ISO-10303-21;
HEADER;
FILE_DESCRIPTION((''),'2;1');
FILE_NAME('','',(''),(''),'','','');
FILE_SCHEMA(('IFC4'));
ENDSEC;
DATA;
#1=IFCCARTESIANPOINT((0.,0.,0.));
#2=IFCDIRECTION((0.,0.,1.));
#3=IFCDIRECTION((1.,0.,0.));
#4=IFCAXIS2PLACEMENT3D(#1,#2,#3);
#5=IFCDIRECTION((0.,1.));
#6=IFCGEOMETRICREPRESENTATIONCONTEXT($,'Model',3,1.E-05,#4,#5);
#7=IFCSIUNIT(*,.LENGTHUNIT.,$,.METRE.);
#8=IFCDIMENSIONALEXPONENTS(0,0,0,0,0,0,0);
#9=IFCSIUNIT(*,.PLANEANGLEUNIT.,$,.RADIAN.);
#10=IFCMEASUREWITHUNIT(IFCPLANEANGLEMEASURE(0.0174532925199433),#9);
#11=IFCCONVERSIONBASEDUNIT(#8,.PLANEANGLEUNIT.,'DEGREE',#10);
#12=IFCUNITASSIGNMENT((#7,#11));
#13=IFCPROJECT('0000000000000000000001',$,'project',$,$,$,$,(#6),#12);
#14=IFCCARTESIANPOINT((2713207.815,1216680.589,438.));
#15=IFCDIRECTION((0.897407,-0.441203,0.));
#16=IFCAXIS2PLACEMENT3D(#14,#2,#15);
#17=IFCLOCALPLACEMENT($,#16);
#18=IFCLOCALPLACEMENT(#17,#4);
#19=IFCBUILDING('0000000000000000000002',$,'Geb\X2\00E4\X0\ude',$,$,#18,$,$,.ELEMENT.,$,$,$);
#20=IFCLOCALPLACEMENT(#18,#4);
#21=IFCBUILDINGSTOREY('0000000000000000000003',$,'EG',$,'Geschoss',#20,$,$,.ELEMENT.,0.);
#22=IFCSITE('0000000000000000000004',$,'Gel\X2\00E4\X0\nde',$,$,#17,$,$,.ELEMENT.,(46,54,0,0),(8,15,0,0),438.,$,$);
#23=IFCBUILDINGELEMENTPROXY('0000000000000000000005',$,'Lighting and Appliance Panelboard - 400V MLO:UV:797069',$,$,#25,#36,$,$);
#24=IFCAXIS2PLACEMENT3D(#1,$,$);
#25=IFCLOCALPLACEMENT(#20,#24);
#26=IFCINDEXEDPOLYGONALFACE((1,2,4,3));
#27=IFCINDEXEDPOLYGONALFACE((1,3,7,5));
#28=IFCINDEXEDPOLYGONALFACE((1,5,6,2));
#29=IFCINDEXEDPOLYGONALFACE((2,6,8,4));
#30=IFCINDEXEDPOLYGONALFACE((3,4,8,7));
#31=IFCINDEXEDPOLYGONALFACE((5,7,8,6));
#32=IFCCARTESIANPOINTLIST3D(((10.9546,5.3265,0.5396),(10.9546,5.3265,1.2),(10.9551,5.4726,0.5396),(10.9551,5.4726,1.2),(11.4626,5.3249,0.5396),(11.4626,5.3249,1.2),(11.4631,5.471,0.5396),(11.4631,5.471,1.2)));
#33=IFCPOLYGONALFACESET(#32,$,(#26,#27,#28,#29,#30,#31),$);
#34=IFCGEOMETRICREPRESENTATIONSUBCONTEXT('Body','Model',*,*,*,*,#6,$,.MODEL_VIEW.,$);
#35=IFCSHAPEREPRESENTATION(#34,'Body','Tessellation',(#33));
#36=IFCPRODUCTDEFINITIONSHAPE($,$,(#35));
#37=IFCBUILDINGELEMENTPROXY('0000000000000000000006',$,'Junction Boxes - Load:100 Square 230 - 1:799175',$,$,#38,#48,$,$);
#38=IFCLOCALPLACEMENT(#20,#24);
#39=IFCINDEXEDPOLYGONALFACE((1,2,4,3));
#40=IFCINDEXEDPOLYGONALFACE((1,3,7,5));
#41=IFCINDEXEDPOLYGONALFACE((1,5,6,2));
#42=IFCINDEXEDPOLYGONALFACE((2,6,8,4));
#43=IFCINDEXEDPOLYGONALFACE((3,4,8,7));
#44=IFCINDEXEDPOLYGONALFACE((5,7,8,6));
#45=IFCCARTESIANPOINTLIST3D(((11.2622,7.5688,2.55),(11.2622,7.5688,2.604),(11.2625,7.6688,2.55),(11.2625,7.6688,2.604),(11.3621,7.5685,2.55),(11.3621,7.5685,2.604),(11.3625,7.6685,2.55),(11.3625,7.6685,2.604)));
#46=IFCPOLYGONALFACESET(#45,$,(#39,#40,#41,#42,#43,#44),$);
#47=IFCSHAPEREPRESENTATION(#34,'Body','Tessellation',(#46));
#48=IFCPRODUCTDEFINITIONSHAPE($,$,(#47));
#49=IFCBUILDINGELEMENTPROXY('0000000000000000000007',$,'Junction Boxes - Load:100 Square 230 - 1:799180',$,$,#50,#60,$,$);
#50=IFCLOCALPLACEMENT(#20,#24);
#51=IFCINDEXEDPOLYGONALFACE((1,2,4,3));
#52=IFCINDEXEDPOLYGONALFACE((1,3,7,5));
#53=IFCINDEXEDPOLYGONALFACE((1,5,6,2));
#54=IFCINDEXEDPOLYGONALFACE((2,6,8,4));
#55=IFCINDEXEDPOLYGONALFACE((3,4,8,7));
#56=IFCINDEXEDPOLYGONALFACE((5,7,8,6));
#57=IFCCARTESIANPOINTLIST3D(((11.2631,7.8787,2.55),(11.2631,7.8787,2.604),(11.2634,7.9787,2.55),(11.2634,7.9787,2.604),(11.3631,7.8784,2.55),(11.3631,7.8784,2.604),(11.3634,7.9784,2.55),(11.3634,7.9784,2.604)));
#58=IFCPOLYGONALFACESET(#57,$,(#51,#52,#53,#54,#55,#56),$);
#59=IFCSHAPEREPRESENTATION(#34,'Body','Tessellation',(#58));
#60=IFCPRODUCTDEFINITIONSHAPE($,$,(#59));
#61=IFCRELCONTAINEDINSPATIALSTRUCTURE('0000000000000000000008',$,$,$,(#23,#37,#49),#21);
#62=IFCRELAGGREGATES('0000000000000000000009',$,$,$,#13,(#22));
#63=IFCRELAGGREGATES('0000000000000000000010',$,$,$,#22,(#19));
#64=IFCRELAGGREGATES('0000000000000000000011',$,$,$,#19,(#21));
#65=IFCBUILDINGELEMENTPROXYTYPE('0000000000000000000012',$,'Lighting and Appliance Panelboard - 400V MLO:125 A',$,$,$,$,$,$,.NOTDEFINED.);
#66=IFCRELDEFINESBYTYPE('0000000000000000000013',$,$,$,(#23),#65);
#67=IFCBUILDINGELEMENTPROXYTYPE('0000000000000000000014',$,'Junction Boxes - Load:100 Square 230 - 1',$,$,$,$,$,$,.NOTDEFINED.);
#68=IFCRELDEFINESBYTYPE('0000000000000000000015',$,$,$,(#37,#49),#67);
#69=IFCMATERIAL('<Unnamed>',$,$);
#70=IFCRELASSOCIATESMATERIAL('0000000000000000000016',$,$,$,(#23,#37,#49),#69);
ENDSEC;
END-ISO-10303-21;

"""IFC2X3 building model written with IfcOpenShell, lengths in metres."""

from ifc_helpers import new_model, entity, si_unit, converted_unit, direction, frame, origin_with_axes, origin_2d_with_axis, place, context, subcontext, project, spatial, rectangle, extrude, material, type_object, element, save


model = new_model("IFC2X3")

# Units and contexts
model_context = context("Model", 3, precision=1e-05, world=origin_with_axes(), true_north=direction((0.0, 1.0)))
body_context = subcontext(model_context, "Body", "Model", "MODEL_VIEW")
ifc_project = project(units=[si_unit("LENGTHUNIT", "METRE"), converted_unit("PLANEANGLEUNIT", "DEGREE", entity("IfcPlaneAngleMeasure", 0.0174532925199433), si_unit("PLANEANGLEUNIT", "RADIAN"), dimensions=[0, 0, 0, 0, 0, 0, 0])], contexts=[model_context])

# Site, building, storey
site_placement = place(None, frame((2713207.815, 1216680.589, 438.0), z_axis=(0.0, 0.0, 1.0), x_axis=(0.897407, -0.441203, 0.0)))
site = spatial("IfcSite", under=ifc_project, at=site_placement, Name="Gelände", CompositionType="ELEMENT", RefLatitude=(46, 54, 0, 0), RefLongitude=(8, 15, 0, 0), RefElevation=438.0)
building_placement = place(site_placement, origin_with_axes())
building = spatial("IfcBuilding", under=site, at=building_placement, Name="Gebäude", CompositionType="ELEMENT")
storey_placement = place(building_placement, origin_with_axes())
storey = spatial("IfcBuildingStorey", under=building, at=storey_placement, Name="EG", ObjectType="Geschoss", CompositionType="ELEMENT", Elevation=0.0)

# Building element proxies
ifc_material = material(Name="<Unnamed>")
building_element_proxy_type_1 = type_object("IfcBuildingElementProxyType", Name="Lighting and Appliance Panelboard - 400V MLO:125 A", PredefinedType="NOTDEFINED")
proxy_placement = place(storey_placement, frame((11.2091, 5.4718, 1.2), z_axis=(0.0, 0.0, 1.0), x_axis=(-0.999995, 0.003142, 0.0)))
element("IfcBuildingElementProxy", 1, at=proxy_placement, inside=storey, type_object=building_element_proxy_type_1, material=ifc_material, Name="Lighting and Appliance Panelboard - 400V MLO:UV:797069", context=body_context, shape_type="SweptSolid", body=[
    extrude(rectangle(XDim=0.6604, YDim=0.508, at=origin_2d_with_axis()), frame((0.0, 0.1461, -0.3302), z_axis=(0.0, -1.0, 0.0), x_axis=(0.0, 0.0, 1.0)), (0.0, 0.0, 1.0), 0.1461),
])
building_element_proxy_type_2 = type_object("IfcBuildingElementProxyType", Name="Junction Boxes - Load:100 Square 230 - 1", PredefinedType="NOTDEFINED")
for number, where, z_axis, x_axis, name in (
    (2, (11.3123, 7.6186, 2.55), (0.0, 0.0, 1.0), (-0.00313, -0.999995, 0.0), "Junction Boxes - Load:100 Square 230 - 1:799175"),
    (3, (11.3133, 7.9285, 2.55), (0.0, 0.0, 1.0), (-0.00313, -0.999995, 0.0), "Junction Boxes - Load:100 Square 230 - 1:799180"),
):
    element("IfcBuildingElementProxy", number, at=place(storey_placement, frame(where, z_axis=z_axis, x_axis=x_axis)), inside=storey, type_object=building_element_proxy_type_2, material=ifc_material, Name=name, context=body_context, shape_type="SweptSolid", body=[
        extrude(rectangle(XDim=0.1, YDim=0.1, at=origin_2d_with_axis()), frame((0.0, 0.0, 0.0), z_axis=(0.0, 0.0, 1.0), x_axis=(-1.0, 0.0, 0.0)), (0.0, 0.0, 1.0), 0.054),
    ])

save(model, "model.ifc")
